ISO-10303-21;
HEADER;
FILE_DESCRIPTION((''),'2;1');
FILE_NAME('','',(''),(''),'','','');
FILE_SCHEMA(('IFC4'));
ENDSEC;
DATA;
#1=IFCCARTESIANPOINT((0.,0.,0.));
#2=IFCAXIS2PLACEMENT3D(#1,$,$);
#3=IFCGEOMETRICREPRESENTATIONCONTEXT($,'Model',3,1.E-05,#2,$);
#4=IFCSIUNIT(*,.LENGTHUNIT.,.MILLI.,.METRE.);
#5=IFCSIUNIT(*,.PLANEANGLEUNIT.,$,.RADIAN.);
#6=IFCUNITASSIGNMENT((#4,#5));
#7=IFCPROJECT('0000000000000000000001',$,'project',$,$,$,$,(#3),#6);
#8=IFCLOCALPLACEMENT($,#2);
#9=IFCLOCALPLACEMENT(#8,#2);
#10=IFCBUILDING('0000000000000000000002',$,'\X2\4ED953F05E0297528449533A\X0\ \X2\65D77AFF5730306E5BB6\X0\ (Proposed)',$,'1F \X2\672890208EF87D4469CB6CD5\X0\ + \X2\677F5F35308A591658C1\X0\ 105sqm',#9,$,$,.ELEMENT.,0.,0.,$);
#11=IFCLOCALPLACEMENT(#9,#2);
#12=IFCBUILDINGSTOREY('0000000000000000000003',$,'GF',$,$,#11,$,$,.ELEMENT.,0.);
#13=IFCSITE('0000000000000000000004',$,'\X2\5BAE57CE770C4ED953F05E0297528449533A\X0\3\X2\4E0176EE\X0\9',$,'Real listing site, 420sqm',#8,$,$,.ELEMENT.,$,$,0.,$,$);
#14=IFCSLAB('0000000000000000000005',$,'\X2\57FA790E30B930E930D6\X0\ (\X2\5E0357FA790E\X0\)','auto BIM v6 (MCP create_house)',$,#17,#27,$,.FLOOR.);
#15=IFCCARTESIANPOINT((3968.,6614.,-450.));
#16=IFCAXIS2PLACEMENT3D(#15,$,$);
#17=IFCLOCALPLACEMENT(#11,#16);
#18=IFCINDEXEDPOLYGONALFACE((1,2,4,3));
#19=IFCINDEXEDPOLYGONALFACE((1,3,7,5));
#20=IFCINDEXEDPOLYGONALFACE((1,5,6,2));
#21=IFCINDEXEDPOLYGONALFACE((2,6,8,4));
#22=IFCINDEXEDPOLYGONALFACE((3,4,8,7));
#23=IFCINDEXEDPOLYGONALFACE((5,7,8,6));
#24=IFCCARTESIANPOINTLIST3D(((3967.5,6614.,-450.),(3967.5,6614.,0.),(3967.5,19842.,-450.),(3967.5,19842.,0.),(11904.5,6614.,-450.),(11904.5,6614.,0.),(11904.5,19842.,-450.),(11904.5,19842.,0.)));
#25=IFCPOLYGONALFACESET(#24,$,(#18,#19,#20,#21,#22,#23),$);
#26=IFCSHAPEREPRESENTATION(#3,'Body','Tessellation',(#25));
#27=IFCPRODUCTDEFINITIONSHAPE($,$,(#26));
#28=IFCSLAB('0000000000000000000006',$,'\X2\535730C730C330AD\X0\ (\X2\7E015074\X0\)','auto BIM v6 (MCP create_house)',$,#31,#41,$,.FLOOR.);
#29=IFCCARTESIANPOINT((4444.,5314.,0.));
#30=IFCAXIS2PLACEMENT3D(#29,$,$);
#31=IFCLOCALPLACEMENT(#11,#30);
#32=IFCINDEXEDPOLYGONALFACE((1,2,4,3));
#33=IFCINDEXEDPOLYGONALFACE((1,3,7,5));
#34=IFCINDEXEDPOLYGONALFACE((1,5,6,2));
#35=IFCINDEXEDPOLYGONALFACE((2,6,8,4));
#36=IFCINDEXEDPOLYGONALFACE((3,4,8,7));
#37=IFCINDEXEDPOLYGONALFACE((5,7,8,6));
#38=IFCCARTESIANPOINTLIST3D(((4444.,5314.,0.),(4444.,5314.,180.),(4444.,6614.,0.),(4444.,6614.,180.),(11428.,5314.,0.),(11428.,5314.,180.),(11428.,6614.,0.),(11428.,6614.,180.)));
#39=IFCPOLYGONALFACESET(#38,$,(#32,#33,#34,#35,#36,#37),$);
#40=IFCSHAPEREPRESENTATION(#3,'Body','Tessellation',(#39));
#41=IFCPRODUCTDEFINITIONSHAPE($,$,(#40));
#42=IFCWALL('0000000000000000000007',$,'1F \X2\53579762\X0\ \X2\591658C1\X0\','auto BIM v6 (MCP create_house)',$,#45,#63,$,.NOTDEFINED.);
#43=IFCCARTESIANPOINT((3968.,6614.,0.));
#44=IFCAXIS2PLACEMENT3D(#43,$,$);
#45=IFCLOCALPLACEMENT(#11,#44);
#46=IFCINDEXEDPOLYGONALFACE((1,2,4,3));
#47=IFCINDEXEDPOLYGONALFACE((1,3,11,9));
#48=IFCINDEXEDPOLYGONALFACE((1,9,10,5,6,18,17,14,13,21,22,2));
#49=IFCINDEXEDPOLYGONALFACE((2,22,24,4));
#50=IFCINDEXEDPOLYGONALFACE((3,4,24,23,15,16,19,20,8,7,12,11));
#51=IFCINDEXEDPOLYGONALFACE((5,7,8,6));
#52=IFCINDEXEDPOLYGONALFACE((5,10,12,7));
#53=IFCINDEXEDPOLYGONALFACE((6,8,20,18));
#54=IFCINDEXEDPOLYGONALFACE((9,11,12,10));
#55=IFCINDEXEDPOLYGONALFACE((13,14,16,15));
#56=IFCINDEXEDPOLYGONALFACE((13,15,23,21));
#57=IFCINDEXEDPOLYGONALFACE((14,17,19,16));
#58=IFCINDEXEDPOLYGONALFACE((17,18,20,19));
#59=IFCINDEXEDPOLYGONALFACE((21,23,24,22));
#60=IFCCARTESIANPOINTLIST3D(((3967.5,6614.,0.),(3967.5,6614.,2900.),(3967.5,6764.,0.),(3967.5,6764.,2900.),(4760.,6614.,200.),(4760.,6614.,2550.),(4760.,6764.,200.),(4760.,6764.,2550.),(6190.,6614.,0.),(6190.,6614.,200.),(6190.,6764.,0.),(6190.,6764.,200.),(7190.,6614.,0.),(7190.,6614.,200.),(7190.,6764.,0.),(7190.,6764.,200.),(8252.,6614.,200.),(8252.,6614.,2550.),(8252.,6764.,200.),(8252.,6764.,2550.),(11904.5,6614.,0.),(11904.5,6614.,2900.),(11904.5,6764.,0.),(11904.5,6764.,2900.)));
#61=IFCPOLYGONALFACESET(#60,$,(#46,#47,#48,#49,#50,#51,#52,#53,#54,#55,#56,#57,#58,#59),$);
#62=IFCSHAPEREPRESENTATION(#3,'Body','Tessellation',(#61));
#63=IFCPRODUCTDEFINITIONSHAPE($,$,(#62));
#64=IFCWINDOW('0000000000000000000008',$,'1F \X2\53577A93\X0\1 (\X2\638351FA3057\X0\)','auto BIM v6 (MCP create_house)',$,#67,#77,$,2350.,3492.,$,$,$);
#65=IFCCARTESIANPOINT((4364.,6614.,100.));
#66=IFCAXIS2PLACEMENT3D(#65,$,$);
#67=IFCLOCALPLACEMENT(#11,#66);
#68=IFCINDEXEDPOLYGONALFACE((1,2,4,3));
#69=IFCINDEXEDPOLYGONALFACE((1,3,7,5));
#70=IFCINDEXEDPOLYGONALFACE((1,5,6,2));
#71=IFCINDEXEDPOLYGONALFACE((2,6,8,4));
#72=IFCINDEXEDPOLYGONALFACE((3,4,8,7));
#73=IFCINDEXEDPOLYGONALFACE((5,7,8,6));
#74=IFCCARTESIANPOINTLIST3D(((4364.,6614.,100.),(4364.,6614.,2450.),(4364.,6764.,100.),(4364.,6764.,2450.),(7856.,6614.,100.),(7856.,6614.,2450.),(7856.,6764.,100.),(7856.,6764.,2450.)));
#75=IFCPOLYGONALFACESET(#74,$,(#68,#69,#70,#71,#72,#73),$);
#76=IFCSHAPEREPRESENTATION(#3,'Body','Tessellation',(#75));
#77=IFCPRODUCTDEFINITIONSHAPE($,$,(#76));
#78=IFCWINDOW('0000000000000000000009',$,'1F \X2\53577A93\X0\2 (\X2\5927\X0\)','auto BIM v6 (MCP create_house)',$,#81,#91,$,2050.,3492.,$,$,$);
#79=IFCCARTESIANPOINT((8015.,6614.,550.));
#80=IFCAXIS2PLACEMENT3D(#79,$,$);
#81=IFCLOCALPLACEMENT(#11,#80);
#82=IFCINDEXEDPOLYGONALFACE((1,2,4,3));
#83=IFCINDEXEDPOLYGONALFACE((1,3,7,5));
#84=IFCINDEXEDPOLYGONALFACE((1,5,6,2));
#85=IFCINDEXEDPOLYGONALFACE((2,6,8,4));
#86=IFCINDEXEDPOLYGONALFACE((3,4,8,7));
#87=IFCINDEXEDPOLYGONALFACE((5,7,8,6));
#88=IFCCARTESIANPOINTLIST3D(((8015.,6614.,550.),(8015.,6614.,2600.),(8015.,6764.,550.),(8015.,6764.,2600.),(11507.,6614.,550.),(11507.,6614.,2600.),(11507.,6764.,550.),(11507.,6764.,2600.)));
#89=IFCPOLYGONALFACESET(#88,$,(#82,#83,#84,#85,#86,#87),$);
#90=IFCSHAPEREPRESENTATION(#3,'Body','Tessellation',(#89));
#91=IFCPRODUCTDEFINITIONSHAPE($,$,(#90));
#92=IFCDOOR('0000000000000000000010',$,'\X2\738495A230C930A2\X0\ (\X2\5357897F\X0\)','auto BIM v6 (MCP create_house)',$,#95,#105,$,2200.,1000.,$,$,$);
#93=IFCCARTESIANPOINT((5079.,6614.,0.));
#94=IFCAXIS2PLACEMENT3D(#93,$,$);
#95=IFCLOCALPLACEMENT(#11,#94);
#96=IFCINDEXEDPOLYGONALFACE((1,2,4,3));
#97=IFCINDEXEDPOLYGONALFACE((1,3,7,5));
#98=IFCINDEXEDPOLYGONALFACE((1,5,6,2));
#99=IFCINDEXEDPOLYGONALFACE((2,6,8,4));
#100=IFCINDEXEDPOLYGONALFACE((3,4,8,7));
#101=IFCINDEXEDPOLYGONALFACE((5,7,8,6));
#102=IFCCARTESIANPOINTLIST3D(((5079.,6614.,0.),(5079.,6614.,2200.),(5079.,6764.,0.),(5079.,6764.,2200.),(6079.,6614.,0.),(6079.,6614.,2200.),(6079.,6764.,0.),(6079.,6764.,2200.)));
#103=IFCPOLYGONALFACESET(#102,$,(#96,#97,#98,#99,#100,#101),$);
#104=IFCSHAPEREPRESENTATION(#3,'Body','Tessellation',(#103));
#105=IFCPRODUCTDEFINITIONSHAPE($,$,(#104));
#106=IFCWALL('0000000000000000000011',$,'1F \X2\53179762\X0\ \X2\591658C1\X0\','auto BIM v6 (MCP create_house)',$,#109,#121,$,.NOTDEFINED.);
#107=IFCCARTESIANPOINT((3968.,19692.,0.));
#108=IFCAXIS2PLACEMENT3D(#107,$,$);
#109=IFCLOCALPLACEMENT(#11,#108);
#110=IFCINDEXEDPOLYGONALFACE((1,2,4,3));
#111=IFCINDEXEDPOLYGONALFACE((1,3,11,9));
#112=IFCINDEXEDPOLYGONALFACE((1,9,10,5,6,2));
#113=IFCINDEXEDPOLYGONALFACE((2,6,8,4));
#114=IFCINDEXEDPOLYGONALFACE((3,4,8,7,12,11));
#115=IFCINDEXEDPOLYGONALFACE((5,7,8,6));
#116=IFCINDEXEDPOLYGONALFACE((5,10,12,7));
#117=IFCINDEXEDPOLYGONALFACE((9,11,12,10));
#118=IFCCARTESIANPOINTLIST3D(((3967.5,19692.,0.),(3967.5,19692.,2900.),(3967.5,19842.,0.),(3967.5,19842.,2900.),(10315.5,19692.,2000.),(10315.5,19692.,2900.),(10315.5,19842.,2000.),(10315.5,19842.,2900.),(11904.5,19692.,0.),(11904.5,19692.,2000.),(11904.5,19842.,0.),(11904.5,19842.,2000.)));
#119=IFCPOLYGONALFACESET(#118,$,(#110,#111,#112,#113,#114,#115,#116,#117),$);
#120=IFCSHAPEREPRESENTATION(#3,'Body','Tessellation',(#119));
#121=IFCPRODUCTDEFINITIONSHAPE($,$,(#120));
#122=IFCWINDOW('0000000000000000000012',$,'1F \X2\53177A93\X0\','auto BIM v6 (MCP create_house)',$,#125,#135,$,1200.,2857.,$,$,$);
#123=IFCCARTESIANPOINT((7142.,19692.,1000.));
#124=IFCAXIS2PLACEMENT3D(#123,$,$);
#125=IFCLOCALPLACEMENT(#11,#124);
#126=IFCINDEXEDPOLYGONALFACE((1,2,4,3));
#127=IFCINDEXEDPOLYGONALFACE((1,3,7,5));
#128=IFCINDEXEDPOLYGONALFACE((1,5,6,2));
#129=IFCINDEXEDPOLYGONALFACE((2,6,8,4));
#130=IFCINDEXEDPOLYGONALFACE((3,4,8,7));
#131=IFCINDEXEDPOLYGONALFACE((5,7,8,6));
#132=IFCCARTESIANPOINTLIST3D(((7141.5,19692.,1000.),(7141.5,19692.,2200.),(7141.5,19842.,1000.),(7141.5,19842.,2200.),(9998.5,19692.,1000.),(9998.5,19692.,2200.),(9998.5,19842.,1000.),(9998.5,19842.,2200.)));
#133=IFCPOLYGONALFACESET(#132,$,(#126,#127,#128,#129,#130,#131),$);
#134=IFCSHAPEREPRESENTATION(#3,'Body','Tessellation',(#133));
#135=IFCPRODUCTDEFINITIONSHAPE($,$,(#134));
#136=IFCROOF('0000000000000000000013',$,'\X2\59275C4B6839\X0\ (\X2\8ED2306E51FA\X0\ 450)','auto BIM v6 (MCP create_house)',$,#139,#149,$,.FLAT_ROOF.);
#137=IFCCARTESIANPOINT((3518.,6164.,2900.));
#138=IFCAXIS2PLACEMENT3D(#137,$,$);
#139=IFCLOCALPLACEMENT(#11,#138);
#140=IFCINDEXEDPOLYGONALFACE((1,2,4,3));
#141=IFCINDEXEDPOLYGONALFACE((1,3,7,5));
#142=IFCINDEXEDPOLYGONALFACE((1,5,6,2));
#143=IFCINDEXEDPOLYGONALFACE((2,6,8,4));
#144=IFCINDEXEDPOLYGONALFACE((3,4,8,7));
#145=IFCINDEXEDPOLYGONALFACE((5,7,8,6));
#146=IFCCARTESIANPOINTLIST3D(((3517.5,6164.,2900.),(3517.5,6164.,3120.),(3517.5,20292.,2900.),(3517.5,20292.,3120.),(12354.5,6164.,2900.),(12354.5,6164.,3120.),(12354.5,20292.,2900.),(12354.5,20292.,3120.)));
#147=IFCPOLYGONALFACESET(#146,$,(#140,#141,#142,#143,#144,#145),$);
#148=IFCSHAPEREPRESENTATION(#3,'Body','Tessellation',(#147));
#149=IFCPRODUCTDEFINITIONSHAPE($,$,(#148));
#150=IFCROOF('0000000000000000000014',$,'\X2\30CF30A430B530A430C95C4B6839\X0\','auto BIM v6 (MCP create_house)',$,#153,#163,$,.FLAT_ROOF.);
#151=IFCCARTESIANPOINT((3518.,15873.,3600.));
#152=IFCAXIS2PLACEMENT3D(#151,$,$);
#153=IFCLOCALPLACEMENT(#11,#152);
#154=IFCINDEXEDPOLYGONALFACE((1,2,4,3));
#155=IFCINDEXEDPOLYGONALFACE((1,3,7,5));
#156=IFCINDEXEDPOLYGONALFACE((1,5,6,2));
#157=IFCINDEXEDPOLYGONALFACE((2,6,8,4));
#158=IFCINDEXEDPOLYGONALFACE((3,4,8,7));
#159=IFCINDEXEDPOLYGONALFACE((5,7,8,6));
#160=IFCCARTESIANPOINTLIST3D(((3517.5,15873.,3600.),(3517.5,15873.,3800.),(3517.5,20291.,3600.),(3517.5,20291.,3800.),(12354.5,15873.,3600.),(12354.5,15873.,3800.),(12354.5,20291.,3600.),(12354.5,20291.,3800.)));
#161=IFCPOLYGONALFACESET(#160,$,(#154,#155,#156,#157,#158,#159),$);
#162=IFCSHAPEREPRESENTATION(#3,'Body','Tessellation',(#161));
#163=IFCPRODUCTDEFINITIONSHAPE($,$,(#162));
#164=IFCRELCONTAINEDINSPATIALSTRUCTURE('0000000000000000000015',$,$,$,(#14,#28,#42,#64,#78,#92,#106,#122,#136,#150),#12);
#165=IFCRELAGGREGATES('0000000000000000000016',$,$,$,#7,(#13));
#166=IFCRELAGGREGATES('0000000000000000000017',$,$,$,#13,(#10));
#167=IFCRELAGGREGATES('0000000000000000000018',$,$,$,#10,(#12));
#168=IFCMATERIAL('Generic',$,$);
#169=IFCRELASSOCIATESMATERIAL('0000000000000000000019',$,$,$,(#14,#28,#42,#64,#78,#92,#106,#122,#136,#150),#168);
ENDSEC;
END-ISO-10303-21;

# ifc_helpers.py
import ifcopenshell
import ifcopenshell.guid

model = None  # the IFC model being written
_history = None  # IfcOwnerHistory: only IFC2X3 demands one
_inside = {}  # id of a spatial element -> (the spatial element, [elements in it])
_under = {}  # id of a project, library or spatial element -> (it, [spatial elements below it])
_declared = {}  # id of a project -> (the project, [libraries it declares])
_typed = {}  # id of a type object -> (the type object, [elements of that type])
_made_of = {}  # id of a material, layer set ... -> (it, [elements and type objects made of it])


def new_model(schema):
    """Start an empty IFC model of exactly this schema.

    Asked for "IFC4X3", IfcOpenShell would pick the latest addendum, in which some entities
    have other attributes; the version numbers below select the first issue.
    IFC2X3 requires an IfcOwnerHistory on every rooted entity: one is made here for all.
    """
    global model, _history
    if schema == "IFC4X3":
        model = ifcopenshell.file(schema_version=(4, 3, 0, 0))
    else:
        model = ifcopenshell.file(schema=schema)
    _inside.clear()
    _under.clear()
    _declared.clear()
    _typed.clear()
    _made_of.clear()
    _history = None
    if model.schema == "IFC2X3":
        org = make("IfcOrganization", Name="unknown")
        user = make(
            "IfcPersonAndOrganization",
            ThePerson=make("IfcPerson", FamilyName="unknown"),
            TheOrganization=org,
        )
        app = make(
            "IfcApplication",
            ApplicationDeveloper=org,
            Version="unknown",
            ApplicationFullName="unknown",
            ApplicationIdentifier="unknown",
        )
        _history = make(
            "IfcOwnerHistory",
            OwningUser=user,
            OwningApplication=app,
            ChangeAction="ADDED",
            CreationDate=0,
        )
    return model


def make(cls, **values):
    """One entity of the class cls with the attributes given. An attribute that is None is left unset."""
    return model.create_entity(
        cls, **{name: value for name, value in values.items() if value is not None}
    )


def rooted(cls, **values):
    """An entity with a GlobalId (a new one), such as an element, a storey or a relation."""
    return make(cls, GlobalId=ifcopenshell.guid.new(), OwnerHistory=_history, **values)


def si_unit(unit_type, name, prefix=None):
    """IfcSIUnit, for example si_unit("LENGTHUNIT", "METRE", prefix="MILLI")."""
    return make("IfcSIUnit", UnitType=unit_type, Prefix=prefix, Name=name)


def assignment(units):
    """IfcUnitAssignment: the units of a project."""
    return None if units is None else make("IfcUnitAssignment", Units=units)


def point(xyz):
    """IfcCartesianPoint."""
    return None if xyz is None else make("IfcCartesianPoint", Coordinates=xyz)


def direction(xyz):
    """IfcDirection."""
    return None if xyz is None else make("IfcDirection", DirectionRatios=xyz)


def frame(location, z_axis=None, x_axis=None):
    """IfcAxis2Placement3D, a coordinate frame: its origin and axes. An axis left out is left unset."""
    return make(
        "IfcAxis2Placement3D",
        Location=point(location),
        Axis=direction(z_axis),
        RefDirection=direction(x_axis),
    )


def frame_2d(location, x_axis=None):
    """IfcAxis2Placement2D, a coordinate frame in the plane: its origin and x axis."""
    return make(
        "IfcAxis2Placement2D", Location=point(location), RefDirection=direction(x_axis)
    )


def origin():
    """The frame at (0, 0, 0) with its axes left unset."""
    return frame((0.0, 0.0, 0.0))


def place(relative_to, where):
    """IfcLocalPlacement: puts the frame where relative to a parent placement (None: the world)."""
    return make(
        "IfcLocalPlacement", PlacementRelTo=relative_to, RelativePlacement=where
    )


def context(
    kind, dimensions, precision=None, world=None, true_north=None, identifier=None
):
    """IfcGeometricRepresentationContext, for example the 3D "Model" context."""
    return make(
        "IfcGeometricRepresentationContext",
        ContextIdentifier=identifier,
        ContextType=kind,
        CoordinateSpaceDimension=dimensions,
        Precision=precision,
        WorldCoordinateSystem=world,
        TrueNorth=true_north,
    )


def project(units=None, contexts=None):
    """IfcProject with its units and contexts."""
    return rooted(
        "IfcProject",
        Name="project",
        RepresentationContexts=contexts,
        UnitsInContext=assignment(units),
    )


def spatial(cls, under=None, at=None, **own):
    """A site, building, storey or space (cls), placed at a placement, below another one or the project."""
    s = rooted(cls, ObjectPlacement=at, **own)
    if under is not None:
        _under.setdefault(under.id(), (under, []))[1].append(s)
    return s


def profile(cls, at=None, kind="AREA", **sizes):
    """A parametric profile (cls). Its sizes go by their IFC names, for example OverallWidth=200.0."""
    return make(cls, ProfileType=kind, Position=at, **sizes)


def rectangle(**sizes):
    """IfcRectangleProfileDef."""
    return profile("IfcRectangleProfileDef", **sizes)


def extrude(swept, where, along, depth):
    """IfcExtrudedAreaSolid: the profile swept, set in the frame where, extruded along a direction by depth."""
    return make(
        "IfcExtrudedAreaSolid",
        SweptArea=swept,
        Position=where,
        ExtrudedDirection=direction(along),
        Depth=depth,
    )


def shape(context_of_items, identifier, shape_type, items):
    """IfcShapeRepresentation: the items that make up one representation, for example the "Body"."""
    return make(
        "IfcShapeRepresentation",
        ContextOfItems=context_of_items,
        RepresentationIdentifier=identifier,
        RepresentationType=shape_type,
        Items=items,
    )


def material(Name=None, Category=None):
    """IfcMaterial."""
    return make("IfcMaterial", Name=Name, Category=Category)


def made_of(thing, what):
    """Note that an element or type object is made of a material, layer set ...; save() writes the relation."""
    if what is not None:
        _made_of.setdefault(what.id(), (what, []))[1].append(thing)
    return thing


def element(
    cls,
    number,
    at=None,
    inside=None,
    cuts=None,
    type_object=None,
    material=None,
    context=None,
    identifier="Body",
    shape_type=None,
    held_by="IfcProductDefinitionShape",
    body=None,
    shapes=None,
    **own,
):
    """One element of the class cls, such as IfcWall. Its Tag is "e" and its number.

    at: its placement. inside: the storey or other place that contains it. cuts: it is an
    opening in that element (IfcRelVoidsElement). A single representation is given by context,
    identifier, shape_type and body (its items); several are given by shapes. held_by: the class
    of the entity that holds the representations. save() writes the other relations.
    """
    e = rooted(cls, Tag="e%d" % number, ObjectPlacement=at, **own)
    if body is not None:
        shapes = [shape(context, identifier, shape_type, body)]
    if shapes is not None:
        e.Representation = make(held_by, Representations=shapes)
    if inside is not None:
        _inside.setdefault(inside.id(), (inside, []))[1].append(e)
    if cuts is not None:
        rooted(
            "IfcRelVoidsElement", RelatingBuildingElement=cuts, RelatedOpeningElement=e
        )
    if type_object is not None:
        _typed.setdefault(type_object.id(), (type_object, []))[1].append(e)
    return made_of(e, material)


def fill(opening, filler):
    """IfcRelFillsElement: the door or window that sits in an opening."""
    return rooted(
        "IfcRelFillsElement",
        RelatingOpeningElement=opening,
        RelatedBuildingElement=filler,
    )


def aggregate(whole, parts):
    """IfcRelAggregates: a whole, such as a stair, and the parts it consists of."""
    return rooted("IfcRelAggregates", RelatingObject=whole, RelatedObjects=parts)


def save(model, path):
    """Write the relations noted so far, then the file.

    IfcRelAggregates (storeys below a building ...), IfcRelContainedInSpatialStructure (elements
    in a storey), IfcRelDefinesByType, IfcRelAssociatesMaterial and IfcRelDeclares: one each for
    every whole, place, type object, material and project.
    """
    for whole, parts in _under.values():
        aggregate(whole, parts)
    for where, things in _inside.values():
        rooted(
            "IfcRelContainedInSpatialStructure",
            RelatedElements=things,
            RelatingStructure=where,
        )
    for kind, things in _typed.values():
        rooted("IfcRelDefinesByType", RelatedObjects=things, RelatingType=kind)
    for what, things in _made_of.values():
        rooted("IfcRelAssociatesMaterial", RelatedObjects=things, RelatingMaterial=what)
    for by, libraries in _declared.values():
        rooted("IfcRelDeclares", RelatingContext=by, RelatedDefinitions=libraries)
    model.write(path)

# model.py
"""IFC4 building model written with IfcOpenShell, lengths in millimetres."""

from ifc_helpers import new_model, si_unit, frame, frame_2d, origin, place, context, project, spatial, rectangle, extrude, material, element, fill, save


model = new_model("IFC4")

# Units and contexts
model_context = context("Model", 3, precision=1e-05, world=origin())
ifc_project = project(units=[si_unit("LENGTHUNIT", "METRE", prefix="MILLI"), si_unit("PLANEANGLEUNIT", "RADIAN")], contexts=[model_context])

# Site, building, storey
site_placement = place(None, origin())
site = spatial("IfcSite", under=ifc_project, at=site_placement, Name="宮城県仙台市青葉区3丁目9", ObjectType="Real listing site, 420sqm", CompositionType="ELEMENT", RefElevation=0.0)
building_placement = place(site_placement, origin())
building = spatial("IfcBuilding", under=site, at=building_placement, Name="仙台市青葉区 旗竿地の家 (Proposed)", ObjectType="1F 木造軸組構法 + 板張り外壁 105sqm", CompositionType="ELEMENT", ElevationOfRefHeight=0.0, ElevationOfTerrain=0.0)
storey_placement = place(building_placement, origin())
storey = spatial("IfcBuildingStorey", under=building, at=storey_placement, Name="GF", CompositionType="ELEMENT", Elevation=0.0)

# Slabs
ifc_material = material(Name="Generic")
slab_1_placement = place(storey_placement, frame((3968.0, 6614.0, -450.0)))
element("IfcSlab", 1, at=slab_1_placement, inside=storey, material=ifc_material, Name="基礎スラブ (布基礎)", Description="auto BIM v6 (MCP create_house)", PredefinedType="FLOOR", context=model_context, shape_type="SweptSolid", body=[
    extrude(rectangle(XDim=7937.0, YDim=13228.0, at=frame_2d((3968.0, 6614.0))), frame((3968.0, 6614.0, -450.0)), (0.0, 0.0, 1.0), 450.0),
])
slab_2_placement = place(storey_placement, frame((4444.0, 5314.0, 0.0)))
element("IfcSlab", 2, at=slab_2_placement, inside=storey, material=ifc_material, Name="南デッキ (縁側)", Description="auto BIM v6 (MCP create_house)", PredefinedType="FLOOR", context=model_context, shape_type="SweptSolid", body=[
    extrude(rectangle(XDim=6984.0, YDim=1300.0, at=frame_2d((3492.0, 650.0))), frame((4444.0, 5314.0, 0.0)), (0.0, 0.0, 1.0), 180.0),
])

# Wall, openings, windows, door
wall_1_placement = place(storey_placement, frame((3968.0, 6614.0, 0.0)))
wall_1 = element("IfcWall", 3, at=wall_1_placement, inside=storey, material=ifc_material, Name="1F 南面 外壁", Description="auto BIM v6 (MCP create_house)", PredefinedType="NOTDEFINED", context=model_context, shape_type="SweptSolid", body=[
    extrude(rectangle(XDim=7937.0, YDim=150.0, at=frame_2d((3968.0, 75.0))), frame((3968.0, 6614.0, 0.0)), (0.0, 0.0, 1.0), 2900.0),
])
opening_1_placement = place(storey_placement, frame((4364.0, 6614.0, 100.0)))
opening_1 = element("IfcOpeningElement", 4, at=opening_1_placement, cuts=wall_1, PredefinedType="NOTDEFINED", context=model_context, shape_type="SweptSolid", body=[
    extrude(rectangle(XDim=3492.0, YDim=150.0, at=frame_2d((1746.0, 75.0))), frame((4364.0, 6614.0, 100.0)), (0.0, 0.0, 1.0), 2350.0),
])
opening_2_placement = place(storey_placement, frame((8015.0, 6614.0, 550.0)))
opening_2 = element("IfcOpeningElement", 5, at=opening_2_placement, cuts=wall_1, PredefinedType="NOTDEFINED", context=model_context, shape_type="SweptSolid", body=[
    extrude(rectangle(XDim=3492.0, YDim=150.0, at=frame_2d((1746.0, 75.0))), frame((8015.0, 6614.0, 550.0)), (0.0, 0.0, 1.0), 2050.0),
])
opening_3_placement = place(storey_placement, frame((5079.0, 6614.0, 0.0)))
opening_3 = element("IfcOpeningElement", 6, at=opening_3_placement, cuts=wall_1, PredefinedType="NOTDEFINED", context=model_context, shape_type="SweptSolid", body=[
    extrude(rectangle(XDim=1000.0, YDim=150.0, at=frame_2d((500.0, 75.0))), frame((5079.0, 6614.0, 0.0)), (0.0, 0.0, 1.0), 2200.0),
])
window_1_placement = place(storey_placement, frame((4364.0, 6614.0, 100.0)))
window_1 = element("IfcWindow", 7, at=window_1_placement, inside=storey, material=ifc_material, Name="1F 南窓1 (掃出し)", Description="auto BIM v6 (MCP create_house)", OverallHeight=2350.0, OverallWidth=3492.0, context=model_context, shape_type="SweptSolid", body=[
    extrude(rectangle(XDim=3492.0, YDim=150.0, at=frame_2d((1746.0, 75.0))), frame((4364.0, 6614.0, 100.0)), (0.0, 0.0, 1.0), 2350.0),
])
fill(opening_1, window_1)
window_2_placement = place(storey_placement, frame((8015.0, 6614.0, 550.0)))
window_2 = element("IfcWindow", 8, at=window_2_placement, inside=storey, material=ifc_material, Name="1F 南窓2 (大)", Description="auto BIM v6 (MCP create_house)", OverallHeight=2050.0, OverallWidth=3492.0, context=model_context, shape_type="SweptSolid", body=[
    extrude(rectangle(XDim=3492.0, YDim=150.0, at=frame_2d((1746.0, 75.0))), frame((8015.0, 6614.0, 550.0)), (0.0, 0.0, 1.0), 2050.0),
])
fill(opening_2, window_2)
door_placement = place(storey_placement, frame((5079.0, 6614.0, 0.0)))
door = element("IfcDoor", 9, at=door_placement, inside=storey, material=ifc_material, Name="玄関ドア (南西)", Description="auto BIM v6 (MCP create_house)", OverallHeight=2200.0, OverallWidth=1000.0, context=model_context, shape_type="SweptSolid", body=[
    extrude(rectangle(XDim=1000.0, YDim=150.0, at=frame_2d((500.0, 75.0))), frame((5079.0, 6614.0, 0.0)), (0.0, 0.0, 1.0), 2200.0),
])
fill(opening_3, door)

# Wall, opening, window
wall_2_placement = place(storey_placement, frame((3968.0, 19692.0, 0.0)))
wall_2 = element("IfcWall", 10, at=wall_2_placement, inside=storey, material=ifc_material, Name="1F 北面 外壁", Description="auto BIM v6 (MCP create_house)", PredefinedType="NOTDEFINED", context=model_context, shape_type="SweptSolid", body=[
    extrude(rectangle(XDim=7937.0, YDim=150.0, at=frame_2d((3968.0, 75.0))), frame((3968.0, 19692.0, 0.0)), (0.0, 0.0, 1.0), 2900.0),
])
opening_4_placement = place(storey_placement, frame((7142.0, 19692.0, 1000.0)))
opening_4 = element("IfcOpeningElement", 11, at=opening_4_placement, cuts=wall_2, PredefinedType="NOTDEFINED", context=model_context, shape_type="SweptSolid", body=[
    extrude(rectangle(XDim=2857.0, YDim=150.0, at=frame_2d((1428.0, 75.0))), frame((7142.0, 19692.0, 1000.0)), (0.0, 0.0, 1.0), 1200.0),
])
window_3_placement = place(storey_placement, frame((7142.0, 19692.0, 1000.0)))
window_3 = element("IfcWindow", 12, at=window_3_placement, inside=storey, material=ifc_material, Name="1F 北窓", Description="auto BIM v6 (MCP create_house)", OverallHeight=1200.0, OverallWidth=2857.0, context=model_context, shape_type="SweptSolid", body=[
    extrude(rectangle(XDim=2857.0, YDim=150.0, at=frame_2d((1428.0, 75.0))), frame((7142.0, 19692.0, 1000.0)), (0.0, 0.0, 1.0), 1200.0),
])
fill(opening_4, window_3)

# Roofs
roof_1_placement = place(storey_placement, frame((3518.0, 6164.0, 2900.0)))
element("IfcRoof", 13, at=roof_1_placement, inside=storey, material=ifc_material, Name="大屋根 (軒の出 450)", Description="auto BIM v6 (MCP create_house)", PredefinedType="FLAT_ROOF", context=model_context, shape_type="SweptSolid", body=[
    extrude(rectangle(XDim=8837.0, YDim=14128.0, at=frame_2d((4418.0, 7064.0))), frame((3518.0, 6164.0, 2900.0)), (0.0, 0.0, 1.0), 220.0),
])
roof_2_placement = place(storey_placement, frame((3518.0, 15873.0, 3600.0)))
element("IfcRoof", 14, at=roof_2_placement, inside=storey, material=ifc_material, Name="ハイサイド屋根", Description="auto BIM v6 (MCP create_house)", PredefinedType="FLAT_ROOF", context=model_context, shape_type="SweptSolid", body=[
    extrude(rectangle(XDim=8837.0, YDim=4418.0, at=frame_2d((4418.0, 2209.0))), frame((3518.0, 15873.0, 3600.0)), (0.0, 0.0, 1.0), 200.0),
])

save(model, "model.ifc")
